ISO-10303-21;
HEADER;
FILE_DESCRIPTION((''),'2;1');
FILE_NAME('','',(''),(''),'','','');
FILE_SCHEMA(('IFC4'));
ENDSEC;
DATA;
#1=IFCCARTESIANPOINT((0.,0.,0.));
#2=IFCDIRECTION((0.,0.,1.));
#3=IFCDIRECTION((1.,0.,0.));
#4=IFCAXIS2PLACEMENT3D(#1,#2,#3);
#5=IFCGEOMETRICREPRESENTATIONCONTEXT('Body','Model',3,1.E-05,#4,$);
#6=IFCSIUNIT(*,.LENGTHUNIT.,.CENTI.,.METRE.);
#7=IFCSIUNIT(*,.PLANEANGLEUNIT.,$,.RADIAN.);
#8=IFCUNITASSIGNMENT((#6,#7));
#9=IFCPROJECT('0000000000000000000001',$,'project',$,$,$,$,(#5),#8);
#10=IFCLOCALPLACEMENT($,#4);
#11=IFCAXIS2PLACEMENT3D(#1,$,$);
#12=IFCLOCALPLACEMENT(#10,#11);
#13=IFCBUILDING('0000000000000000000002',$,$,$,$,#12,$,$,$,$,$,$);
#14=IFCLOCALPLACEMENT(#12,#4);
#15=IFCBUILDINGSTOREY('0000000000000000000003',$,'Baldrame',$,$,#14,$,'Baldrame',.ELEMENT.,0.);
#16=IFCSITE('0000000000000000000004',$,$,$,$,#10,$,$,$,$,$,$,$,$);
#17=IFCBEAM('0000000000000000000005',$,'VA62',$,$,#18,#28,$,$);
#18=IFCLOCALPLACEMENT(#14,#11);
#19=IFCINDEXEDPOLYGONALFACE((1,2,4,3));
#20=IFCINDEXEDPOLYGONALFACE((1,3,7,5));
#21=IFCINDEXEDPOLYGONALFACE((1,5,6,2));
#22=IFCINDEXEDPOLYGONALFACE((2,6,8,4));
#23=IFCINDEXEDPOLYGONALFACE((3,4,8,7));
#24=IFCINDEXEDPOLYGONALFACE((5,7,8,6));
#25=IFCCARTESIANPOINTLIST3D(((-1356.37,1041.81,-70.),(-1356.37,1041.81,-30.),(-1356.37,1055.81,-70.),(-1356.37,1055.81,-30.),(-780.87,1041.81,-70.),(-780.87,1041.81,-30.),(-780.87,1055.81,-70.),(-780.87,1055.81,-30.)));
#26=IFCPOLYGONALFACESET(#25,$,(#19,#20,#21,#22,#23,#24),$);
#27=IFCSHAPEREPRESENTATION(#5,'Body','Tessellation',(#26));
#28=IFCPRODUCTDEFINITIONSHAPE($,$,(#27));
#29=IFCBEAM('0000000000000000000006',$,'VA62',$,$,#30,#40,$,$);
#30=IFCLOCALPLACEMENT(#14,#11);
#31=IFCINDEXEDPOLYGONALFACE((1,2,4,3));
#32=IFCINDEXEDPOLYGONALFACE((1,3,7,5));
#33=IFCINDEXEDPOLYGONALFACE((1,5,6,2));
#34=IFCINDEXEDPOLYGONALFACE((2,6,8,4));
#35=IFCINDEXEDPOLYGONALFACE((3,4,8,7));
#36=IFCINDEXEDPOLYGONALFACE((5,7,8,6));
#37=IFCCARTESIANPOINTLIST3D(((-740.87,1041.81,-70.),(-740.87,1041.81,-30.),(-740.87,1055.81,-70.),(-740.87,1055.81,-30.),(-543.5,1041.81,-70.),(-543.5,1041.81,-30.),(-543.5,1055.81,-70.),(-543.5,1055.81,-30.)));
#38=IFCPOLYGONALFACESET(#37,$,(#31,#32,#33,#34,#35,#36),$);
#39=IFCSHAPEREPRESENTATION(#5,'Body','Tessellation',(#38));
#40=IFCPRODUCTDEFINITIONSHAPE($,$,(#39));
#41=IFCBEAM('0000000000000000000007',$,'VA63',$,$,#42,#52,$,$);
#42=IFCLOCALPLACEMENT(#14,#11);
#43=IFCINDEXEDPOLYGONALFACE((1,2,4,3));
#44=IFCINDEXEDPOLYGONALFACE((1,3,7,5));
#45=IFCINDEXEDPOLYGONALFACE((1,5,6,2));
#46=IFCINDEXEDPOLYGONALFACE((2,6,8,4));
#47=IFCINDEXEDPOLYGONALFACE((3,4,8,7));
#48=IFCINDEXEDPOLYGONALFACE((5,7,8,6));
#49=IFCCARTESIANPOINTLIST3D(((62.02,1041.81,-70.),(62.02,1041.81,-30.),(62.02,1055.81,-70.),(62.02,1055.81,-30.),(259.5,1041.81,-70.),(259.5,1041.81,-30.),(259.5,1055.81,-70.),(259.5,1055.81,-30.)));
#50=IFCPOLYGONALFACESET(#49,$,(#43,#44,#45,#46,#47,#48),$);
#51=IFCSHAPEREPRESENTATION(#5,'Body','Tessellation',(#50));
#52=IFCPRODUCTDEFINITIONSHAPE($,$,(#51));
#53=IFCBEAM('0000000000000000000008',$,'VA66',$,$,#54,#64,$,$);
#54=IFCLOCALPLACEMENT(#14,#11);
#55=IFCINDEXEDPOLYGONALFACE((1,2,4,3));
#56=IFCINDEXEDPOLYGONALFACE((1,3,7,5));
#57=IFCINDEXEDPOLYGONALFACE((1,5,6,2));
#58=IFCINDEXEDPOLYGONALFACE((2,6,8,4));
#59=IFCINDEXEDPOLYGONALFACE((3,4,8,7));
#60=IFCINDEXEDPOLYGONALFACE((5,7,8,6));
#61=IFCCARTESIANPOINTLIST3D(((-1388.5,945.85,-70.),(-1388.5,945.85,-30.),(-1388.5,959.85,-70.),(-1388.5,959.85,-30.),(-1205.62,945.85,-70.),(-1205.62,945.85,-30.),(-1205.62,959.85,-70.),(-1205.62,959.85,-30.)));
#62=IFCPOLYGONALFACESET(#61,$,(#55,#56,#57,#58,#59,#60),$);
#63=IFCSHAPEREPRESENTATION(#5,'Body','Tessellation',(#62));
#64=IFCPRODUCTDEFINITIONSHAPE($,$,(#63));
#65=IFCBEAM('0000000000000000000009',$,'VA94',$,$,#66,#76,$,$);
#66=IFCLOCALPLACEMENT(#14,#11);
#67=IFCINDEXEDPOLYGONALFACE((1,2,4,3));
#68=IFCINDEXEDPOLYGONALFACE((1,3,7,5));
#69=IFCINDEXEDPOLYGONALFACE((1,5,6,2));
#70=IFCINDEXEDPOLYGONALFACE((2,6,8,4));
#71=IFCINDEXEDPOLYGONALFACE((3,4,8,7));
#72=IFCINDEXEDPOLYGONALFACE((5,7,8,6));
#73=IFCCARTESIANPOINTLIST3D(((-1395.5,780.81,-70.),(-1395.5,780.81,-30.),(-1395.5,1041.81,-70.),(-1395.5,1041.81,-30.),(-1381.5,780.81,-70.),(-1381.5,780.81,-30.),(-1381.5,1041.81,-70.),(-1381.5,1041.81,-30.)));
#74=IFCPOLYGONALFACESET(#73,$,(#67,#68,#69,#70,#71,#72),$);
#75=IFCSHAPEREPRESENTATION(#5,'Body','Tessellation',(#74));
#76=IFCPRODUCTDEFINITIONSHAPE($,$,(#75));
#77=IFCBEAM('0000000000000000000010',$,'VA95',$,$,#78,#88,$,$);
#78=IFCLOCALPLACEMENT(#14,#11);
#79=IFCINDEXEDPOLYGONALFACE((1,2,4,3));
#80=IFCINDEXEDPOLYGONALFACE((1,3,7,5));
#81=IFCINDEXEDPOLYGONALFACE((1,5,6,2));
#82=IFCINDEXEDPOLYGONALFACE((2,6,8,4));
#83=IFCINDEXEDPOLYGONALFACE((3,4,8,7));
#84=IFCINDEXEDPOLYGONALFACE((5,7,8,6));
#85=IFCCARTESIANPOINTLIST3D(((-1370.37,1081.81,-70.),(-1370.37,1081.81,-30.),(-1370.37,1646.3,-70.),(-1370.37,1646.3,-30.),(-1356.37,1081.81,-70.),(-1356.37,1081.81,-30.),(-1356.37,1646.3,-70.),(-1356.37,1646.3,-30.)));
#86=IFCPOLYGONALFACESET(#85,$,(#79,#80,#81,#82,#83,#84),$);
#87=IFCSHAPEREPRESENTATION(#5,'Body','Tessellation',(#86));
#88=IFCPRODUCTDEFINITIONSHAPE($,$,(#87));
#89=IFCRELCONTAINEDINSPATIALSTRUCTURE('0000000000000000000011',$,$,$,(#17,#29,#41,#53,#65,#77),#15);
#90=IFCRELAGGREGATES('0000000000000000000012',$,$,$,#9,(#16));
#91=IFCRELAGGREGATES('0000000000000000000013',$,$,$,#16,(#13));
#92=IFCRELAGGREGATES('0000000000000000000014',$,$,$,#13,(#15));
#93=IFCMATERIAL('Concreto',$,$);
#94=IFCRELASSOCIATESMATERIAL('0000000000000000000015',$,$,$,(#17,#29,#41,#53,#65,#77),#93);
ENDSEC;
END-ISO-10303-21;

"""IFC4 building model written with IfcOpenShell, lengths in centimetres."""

from ifc_helpers import new_model, si_unit, frame, origin, origin_with_axes, origin_2d_with_axis, place, context, project, spatial, rectangle, extrude, material, element, save


model = new_model("IFC4")

# Units and contexts
model_context = context("Model", 3, precision=1e-05, world=origin_with_axes(), identifier="Body")
ifc_project = project(units=[si_unit("LENGTHUNIT", "METRE", prefix="CENTI"), si_unit("PLANEANGLEUNIT", "RADIAN")], contexts=[model_context])

# Site, building, storey
site_placement = place(None, origin_with_axes())
site = spatial("IfcSite", under=ifc_project, at=site_placement)
building_placement = place(site_placement, origin())
building = spatial("IfcBuilding", under=site, at=building_placement)
storey_placement = place(building_placement, origin_with_axes())
storey = spatial("IfcBuildingStorey", under=building, at=storey_placement, Name="Baldrame", LongName="Baldrame", CompositionType="ELEMENT", Elevation=0.0)

# Shared definitions
ifc_material = material(Name="Concreto")

# Beams
beam_1_placement = place(storey_placement, frame((-1068.62, 1048.81, -30.0), z_axis=(0.0, 0.0, 1.0), x_axis=(1.0, 0.0, 0.0)))
element("IfcBeam", 1, at=beam_1_placement, inside=storey, material=ifc_material, Name="VA62", context=model_context, shape_type="SolidModel", body=[
    extrude(rectangle(XDim=14.0, YDim=40.0, at=origin_2d_with_axis()), frame((-287.75, 0.0, -20.0), z_axis=(1.0, 0.0, 0.0), x_axis=(0.0, 1.0, 0.0)), (0.0, 0.0, 1.0), 575.5),
])
beam_2_placement = place(storey_placement, frame((-642.18, 1048.81, -30.0), z_axis=(0.0, 0.0, 1.0), x_axis=(1.0, 0.0, 0.0)))
element("IfcBeam", 2, at=beam_2_placement, inside=storey, material=ifc_material, Name="VA62", context=model_context, shape_type="SolidModel", body=[
    extrude(rectangle(XDim=14.0, YDim=40.0, at=origin_2d_with_axis()), frame((-98.69, 0.0, -20.0), z_axis=(1.0, 0.0, 0.0), x_axis=(0.0, 1.0, 0.0)), (0.0, 0.0, 1.0), 197.37),
])
beam_3_placement = place(storey_placement, frame((160.76, 1048.81, -30.0), z_axis=(0.0, 0.0, 1.0), x_axis=(1.0, 0.0, 0.0)))
element("IfcBeam", 3, at=beam_3_placement, inside=storey, material=ifc_material, Name="VA63", context=model_context, shape_type="SolidModel", body=[
    extrude(rectangle(XDim=14.0, YDim=40.0, at=origin_2d_with_axis()), frame((-98.74, 0.0, -20.0), z_axis=(1.0, 0.0, 0.0), x_axis=(0.0, 1.0, 0.0)), (0.0, 0.0, 1.0), 197.48),
])
beam_4_placement = place(storey_placement, frame((-1297.06, 952.85, -30.0), z_axis=(0.0, 0.0, 1.0), x_axis=(1.0, 0.0, 0.0)))
element("IfcBeam", 4, at=beam_4_placement, inside=storey, material=ifc_material, Name="VA66", context=model_context, shape_type="SolidModel", body=[
    extrude(rectangle(XDim=14.0, YDim=40.0, at=origin_2d_with_axis()), frame((-91.44, 0.0, -20.0), z_axis=(1.0, 0.0, 0.0), x_axis=(0.0, 1.0, 0.0)), (0.0, 0.0, 1.0), 182.88),
])
beam_5_placement = place(storey_placement, frame((-1388.5, 911.31, -30.0), z_axis=(0.0, 0.0, 1.0), x_axis=(1.0, 0.0, 0.0)))
element("IfcBeam", 5, at=beam_5_placement, inside=storey, material=ifc_material, Name="VA94", context=model_context, shape_type="SolidModel", body=[
    extrude(rectangle(XDim=14.0, YDim=40.0, at=origin_2d_with_axis()), frame((0.0, -130.5, -20.0), z_axis=(0.0, 1.0, 0.0), x_axis=(-1.0, 0.0, 0.0)), (0.0, 0.0, 1.0), 261.0),
])
beam_6_placement = place(storey_placement, frame((-1363.37, 1364.06, -30.0), z_axis=(0.0, 0.0, 1.0), x_axis=(1.0, 0.0, 0.0)))
element("IfcBeam", 6, at=beam_6_placement, inside=storey, material=ifc_material, Name="VA95", context=model_context, shape_type="SolidModel", body=[
    extrude(rectangle(XDim=14.0, YDim=40.0, at=origin_2d_with_axis()), frame((0.0, -282.25, -20.0), z_axis=(0.0, 1.0, 0.0), x_axis=(-1.0, 0.0, 0.0)), (0.0, 0.0, 1.0), 564.49),
])

save(model, "model.ifc")
